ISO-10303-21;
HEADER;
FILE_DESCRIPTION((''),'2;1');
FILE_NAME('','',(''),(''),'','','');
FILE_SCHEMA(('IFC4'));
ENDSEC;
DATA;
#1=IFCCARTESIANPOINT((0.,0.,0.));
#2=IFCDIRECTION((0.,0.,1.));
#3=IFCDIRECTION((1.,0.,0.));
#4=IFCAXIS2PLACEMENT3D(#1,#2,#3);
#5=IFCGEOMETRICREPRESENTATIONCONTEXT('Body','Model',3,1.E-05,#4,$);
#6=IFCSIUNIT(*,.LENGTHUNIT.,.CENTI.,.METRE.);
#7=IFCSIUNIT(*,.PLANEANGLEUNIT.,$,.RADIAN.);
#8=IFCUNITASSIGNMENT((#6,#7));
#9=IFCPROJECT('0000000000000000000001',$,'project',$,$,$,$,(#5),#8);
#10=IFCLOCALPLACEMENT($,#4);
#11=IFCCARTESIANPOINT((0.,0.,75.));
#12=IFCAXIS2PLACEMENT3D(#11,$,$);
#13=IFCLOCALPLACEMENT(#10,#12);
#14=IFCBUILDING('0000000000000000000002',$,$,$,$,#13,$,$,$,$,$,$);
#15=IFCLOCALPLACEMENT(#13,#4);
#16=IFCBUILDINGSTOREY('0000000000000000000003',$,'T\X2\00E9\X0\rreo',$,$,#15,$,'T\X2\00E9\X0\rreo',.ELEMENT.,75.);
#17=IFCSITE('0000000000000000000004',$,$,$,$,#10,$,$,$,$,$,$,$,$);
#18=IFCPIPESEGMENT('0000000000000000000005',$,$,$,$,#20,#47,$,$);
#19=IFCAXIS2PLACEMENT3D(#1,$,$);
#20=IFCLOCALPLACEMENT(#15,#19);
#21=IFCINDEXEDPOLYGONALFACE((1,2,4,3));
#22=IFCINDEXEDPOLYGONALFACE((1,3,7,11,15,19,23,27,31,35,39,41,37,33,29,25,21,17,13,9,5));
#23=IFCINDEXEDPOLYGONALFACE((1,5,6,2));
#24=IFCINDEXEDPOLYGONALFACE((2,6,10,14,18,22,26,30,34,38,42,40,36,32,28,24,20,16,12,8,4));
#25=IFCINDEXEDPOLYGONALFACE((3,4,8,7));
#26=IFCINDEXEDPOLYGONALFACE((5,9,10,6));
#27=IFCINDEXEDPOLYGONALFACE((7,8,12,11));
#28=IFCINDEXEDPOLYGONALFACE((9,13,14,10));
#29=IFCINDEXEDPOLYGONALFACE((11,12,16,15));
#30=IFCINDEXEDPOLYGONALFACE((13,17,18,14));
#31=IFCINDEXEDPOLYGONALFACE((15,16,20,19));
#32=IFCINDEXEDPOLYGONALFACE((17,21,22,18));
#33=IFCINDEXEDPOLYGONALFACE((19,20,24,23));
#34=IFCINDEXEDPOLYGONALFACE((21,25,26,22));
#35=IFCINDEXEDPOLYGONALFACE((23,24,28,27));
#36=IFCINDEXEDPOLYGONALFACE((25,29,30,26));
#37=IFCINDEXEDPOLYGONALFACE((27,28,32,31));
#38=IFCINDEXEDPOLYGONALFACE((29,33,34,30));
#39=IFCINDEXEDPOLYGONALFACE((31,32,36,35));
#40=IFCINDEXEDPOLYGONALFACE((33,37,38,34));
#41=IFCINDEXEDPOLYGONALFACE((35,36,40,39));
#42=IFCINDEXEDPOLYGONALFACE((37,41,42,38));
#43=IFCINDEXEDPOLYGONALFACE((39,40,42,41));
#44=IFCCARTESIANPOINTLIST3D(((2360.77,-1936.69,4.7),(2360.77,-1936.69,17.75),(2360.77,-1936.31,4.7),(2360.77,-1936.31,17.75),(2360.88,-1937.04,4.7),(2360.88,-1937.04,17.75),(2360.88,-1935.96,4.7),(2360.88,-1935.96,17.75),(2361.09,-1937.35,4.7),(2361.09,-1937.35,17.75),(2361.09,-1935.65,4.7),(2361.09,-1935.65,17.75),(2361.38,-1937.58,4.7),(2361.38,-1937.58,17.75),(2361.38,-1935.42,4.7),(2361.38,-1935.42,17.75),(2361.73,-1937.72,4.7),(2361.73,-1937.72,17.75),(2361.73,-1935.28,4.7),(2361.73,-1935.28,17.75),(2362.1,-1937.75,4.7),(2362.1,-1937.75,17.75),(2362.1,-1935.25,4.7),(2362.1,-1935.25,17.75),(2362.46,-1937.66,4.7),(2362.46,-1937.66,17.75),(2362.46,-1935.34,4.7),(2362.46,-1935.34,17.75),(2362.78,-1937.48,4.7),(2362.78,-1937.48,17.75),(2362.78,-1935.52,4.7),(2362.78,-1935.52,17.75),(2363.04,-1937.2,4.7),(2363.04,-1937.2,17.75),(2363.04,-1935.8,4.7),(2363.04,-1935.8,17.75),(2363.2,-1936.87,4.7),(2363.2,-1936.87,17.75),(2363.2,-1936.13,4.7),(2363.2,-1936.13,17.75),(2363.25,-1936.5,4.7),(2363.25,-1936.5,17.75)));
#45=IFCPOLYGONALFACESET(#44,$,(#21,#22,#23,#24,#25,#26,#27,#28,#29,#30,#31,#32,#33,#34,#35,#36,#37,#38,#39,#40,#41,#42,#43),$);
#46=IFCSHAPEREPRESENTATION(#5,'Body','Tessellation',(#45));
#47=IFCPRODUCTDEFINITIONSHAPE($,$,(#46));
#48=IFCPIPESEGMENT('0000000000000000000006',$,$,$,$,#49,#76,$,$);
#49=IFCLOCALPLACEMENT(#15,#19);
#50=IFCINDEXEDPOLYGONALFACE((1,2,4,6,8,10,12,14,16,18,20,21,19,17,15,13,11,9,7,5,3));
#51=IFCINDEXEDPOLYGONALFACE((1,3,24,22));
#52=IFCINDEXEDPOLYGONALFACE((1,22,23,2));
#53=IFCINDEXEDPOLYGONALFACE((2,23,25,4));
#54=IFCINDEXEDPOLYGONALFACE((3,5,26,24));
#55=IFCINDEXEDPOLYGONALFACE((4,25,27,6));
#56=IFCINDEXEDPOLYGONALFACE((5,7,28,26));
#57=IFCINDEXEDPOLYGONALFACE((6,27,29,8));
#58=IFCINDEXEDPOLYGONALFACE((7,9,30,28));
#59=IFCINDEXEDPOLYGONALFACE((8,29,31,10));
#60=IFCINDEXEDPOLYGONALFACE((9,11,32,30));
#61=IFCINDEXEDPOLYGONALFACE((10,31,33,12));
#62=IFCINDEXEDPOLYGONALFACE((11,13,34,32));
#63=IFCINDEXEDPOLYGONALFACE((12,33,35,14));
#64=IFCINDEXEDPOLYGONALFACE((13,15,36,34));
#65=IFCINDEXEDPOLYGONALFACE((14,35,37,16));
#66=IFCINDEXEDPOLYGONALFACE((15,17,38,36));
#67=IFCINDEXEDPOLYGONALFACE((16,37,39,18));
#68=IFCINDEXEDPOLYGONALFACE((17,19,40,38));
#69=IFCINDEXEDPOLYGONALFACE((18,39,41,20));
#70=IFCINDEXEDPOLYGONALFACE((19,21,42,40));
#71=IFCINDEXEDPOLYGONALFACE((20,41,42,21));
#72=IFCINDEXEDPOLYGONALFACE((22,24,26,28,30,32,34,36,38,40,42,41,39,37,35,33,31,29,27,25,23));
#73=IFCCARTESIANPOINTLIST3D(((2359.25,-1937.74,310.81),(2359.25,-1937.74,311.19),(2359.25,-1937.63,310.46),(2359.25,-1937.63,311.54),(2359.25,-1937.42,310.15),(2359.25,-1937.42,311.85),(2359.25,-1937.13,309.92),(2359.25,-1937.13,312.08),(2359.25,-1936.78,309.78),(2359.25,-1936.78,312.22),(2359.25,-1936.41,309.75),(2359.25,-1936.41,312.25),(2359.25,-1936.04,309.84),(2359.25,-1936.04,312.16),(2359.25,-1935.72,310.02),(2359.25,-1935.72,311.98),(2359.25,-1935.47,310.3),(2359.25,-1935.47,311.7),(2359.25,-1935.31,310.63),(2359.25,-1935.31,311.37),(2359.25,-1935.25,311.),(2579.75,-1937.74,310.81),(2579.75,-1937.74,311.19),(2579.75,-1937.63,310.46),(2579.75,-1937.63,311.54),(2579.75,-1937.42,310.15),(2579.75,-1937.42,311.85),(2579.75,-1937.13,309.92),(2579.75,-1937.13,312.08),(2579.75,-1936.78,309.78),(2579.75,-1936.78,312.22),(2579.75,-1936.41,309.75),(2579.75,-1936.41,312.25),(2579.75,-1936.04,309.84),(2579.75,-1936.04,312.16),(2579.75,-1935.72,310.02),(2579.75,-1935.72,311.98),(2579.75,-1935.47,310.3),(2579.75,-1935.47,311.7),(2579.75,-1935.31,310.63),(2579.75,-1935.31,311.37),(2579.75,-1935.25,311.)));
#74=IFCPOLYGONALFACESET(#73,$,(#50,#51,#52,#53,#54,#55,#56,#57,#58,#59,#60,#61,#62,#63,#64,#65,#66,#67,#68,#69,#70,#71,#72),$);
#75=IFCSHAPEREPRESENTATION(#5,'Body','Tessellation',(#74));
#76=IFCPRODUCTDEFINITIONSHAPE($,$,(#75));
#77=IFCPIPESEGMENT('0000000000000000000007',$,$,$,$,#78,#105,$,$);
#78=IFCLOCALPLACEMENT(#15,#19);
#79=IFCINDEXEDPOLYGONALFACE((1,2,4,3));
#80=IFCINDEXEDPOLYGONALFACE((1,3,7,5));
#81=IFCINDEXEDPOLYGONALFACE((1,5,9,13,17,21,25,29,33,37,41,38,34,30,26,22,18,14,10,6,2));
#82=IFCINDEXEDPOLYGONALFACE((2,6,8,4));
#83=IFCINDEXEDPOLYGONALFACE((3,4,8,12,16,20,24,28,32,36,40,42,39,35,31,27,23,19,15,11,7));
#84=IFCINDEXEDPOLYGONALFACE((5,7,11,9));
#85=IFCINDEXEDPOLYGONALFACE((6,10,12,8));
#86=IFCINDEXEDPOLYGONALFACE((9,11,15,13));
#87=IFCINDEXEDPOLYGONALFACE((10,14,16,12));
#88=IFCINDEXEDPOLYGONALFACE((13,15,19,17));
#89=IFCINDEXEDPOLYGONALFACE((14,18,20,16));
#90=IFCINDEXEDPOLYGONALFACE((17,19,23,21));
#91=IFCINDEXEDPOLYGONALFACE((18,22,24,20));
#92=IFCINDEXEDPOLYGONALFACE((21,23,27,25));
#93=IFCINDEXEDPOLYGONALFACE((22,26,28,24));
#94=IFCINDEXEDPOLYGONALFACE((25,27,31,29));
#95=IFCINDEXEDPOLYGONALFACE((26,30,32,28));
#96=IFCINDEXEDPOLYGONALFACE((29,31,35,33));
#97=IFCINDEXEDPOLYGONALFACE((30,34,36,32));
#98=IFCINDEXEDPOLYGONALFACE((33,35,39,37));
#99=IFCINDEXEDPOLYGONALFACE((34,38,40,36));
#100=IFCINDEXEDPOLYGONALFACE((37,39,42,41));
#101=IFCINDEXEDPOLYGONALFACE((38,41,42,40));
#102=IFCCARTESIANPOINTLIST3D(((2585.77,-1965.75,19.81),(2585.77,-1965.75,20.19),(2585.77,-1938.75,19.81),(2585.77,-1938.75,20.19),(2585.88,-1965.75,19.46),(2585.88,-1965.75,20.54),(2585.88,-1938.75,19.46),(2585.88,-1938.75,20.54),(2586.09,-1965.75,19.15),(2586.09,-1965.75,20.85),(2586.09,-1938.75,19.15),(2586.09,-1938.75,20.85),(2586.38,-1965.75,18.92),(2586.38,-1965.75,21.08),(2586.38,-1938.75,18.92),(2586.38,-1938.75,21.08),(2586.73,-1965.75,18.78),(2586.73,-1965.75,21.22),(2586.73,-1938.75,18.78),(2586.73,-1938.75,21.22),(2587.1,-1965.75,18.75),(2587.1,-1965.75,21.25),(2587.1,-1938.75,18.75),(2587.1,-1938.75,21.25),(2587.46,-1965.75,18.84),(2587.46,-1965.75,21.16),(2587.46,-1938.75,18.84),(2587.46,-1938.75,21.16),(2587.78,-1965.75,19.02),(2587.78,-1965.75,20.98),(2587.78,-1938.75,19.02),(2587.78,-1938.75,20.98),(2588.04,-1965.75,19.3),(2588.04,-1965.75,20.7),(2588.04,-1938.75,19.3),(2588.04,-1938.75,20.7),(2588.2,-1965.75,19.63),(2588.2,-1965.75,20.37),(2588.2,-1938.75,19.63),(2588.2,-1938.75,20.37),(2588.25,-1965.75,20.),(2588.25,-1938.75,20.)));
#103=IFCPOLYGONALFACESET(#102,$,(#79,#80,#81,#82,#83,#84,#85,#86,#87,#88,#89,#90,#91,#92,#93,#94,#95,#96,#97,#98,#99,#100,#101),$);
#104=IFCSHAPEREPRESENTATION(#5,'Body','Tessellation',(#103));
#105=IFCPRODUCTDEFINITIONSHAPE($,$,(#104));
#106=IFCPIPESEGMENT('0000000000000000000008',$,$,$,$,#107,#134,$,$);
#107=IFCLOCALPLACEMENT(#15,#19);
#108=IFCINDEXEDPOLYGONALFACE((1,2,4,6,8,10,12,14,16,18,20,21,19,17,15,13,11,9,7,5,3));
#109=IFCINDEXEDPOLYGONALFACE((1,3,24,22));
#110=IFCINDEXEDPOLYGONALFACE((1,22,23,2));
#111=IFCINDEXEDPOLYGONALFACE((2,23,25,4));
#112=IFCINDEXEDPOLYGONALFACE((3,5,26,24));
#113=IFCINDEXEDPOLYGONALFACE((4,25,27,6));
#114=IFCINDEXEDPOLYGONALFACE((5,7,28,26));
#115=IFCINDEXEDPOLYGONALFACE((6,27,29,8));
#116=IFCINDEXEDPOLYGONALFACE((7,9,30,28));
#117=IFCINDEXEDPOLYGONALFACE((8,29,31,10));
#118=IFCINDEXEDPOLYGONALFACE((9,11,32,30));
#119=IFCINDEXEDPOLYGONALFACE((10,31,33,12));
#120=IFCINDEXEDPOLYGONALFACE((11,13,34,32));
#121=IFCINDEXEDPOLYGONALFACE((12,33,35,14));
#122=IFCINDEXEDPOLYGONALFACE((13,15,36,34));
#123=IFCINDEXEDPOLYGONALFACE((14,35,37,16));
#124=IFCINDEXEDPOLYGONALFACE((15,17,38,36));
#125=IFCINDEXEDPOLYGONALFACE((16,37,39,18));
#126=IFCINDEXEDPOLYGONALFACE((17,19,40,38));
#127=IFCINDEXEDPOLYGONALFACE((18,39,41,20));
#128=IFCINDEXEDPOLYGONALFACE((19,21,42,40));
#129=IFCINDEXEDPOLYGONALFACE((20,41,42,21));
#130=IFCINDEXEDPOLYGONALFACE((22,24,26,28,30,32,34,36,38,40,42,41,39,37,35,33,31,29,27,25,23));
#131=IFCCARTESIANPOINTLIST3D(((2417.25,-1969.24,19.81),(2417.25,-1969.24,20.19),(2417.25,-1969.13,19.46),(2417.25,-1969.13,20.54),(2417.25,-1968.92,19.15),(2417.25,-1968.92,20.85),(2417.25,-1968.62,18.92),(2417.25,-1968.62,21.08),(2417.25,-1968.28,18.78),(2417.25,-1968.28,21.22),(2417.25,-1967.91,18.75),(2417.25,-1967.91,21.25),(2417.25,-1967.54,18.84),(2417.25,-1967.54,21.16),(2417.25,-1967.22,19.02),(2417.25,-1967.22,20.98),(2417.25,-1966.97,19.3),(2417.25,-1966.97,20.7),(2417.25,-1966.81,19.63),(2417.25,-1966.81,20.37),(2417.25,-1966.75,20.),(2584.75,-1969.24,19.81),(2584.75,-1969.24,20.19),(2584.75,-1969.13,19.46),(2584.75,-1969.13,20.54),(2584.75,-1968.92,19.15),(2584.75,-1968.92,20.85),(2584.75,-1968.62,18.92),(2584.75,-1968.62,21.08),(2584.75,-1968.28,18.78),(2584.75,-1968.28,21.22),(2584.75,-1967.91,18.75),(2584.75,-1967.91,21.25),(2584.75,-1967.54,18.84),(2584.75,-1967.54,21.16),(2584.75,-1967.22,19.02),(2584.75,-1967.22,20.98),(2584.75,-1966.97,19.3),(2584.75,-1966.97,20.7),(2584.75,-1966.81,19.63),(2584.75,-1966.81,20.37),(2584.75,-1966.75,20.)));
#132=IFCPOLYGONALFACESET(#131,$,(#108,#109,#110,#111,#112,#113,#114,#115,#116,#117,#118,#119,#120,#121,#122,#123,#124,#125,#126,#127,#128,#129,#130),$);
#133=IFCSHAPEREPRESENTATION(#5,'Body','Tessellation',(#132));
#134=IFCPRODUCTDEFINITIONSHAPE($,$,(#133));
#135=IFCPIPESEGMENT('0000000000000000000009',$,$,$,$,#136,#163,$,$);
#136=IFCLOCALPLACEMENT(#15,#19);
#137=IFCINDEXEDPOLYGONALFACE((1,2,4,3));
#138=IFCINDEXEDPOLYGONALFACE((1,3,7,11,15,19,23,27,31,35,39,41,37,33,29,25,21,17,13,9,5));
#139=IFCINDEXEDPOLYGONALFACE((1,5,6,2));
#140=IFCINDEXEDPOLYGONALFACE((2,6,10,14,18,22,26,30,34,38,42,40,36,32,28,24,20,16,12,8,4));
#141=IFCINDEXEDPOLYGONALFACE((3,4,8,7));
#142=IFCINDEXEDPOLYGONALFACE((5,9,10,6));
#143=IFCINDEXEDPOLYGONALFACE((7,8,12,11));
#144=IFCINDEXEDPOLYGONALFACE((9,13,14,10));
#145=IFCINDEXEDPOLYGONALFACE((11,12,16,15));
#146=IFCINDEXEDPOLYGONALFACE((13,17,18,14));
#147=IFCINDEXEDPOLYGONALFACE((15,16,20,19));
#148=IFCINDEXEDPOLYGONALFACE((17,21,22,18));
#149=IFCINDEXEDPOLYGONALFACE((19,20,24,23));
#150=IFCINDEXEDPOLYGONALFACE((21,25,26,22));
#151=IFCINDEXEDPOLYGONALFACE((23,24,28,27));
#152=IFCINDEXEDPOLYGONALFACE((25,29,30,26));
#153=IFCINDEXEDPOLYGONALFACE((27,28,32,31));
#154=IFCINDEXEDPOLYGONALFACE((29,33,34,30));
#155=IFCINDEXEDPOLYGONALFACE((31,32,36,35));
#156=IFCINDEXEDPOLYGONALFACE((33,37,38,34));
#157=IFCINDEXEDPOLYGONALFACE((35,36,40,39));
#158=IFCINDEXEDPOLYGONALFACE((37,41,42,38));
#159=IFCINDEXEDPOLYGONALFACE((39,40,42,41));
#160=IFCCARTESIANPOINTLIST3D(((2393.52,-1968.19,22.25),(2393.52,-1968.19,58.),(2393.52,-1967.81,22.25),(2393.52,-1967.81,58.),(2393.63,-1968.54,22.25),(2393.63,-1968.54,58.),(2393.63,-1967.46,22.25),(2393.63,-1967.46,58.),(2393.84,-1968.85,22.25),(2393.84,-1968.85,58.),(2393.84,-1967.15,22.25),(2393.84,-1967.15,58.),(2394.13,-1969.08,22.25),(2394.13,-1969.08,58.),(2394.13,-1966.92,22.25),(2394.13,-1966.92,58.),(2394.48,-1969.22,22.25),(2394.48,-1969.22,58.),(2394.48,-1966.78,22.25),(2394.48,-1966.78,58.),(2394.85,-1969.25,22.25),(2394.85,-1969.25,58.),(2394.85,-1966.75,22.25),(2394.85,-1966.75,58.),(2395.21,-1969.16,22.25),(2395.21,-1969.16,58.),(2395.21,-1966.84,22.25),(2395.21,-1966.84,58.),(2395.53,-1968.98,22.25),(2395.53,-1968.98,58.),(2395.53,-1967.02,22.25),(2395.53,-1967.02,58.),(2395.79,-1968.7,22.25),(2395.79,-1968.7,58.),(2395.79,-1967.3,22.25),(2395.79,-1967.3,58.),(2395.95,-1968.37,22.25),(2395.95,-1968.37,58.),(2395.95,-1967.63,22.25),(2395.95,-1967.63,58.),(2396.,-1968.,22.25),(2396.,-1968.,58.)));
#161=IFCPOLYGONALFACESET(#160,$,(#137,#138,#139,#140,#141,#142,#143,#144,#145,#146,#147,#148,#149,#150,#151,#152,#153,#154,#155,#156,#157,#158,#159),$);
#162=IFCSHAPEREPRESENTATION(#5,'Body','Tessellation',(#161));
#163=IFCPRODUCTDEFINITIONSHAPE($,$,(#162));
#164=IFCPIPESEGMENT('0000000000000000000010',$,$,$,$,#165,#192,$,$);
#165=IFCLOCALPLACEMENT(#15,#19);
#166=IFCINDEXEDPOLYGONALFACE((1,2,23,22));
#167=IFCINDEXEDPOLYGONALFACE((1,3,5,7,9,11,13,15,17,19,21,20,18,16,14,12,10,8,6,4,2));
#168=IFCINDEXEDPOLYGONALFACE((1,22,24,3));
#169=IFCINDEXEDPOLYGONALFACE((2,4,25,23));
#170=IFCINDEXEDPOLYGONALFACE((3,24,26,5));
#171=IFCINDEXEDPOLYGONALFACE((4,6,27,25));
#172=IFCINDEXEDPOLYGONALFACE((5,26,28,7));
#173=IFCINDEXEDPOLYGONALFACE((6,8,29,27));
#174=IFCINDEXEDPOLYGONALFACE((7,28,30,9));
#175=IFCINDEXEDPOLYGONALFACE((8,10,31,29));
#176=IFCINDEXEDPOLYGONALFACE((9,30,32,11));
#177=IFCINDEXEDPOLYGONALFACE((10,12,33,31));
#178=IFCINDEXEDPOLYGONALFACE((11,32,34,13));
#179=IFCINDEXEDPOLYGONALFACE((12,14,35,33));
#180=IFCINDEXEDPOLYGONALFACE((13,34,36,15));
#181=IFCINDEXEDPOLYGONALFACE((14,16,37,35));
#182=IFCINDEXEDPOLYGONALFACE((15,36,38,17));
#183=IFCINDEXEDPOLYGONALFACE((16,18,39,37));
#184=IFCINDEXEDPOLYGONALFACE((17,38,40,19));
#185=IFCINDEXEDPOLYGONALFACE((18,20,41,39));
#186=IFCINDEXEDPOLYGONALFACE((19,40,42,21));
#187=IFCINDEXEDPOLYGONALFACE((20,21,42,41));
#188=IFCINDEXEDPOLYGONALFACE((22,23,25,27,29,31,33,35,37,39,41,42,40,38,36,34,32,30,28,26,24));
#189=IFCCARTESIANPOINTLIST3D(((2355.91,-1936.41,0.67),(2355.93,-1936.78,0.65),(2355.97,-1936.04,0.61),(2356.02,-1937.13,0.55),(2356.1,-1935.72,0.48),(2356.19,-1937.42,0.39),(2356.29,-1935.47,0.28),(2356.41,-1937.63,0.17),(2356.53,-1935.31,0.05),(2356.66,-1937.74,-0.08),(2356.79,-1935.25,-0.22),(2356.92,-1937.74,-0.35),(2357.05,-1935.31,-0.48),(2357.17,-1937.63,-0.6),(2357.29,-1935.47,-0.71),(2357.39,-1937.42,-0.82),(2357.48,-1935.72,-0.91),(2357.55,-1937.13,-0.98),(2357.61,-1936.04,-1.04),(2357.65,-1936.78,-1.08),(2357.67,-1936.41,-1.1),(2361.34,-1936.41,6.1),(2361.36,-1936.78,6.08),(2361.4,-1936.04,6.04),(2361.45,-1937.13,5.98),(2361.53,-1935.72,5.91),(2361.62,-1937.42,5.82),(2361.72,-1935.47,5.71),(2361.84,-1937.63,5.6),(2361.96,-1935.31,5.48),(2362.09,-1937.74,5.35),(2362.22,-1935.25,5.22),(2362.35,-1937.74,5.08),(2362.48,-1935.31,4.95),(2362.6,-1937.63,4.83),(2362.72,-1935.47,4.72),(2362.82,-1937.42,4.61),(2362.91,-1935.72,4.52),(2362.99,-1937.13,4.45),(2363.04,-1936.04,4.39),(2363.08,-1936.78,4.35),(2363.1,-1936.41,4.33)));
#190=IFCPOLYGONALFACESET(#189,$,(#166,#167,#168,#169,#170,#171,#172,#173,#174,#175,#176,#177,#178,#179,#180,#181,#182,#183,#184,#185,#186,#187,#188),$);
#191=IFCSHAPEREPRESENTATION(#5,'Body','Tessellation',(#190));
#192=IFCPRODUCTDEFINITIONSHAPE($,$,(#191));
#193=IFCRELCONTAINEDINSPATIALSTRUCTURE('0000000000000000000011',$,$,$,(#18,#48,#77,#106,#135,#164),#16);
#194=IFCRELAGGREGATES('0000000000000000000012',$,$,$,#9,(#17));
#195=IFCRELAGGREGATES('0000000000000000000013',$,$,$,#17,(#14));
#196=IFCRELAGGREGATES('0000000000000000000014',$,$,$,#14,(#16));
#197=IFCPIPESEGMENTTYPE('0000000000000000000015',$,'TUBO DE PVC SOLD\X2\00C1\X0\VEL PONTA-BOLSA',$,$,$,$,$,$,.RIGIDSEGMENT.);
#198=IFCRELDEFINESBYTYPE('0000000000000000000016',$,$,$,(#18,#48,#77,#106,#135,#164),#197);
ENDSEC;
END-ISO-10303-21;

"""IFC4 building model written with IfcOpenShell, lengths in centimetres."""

from ifc_helpers import new_model, si_unit, frame, origin_with_axes, origin_2d_with_axis, place, context, project, spatial, circle, extrude, type_object, element, save


model = new_model("IFC4")

# Units and contexts
model_context = context("Model", 3, precision=1e-05, world=origin_with_axes(), identifier="Body")
ifc_project = project(units=[si_unit("LENGTHUNIT", "METRE", prefix="CENTI"), si_unit("PLANEANGLEUNIT", "RADIAN")], contexts=[model_context])

# Site, building, storey
site_placement = place(None, origin_with_axes())
site = spatial("IfcSite", under=ifc_project, at=site_placement)
building_placement = place(site_placement, frame((0.0, 0.0, 75.0)))
building = spatial("IfcBuilding", under=site, at=building_placement)
storey_placement = place(building_placement, origin_with_axes())
storey = spatial("IfcBuildingStorey", under=building, at=storey_placement, Name="Térreo", LongName="Térreo", CompositionType="ELEMENT", Elevation=75.0)

# Pipe segments
pipe_segment_type_1 = type_object("IfcPipeSegmentType", Name="TUBO DE PVC SOLDÁVEL PONTA-BOLSA", PredefinedType="RIGIDSEGMENT")
pipe_segment_1_placement = place(storey_placement, frame((2362.0, -1936.5, 17.75), z_axis=(0.0, 0.0, 1.0), x_axis=(1.0, 0.0, 0.0)))
element("IfcPipeSegment", 1, at=pipe_segment_1_placement, inside=storey, type_object=pipe_segment_type_1, context=model_context, shape_type="SolidModel", body=[
    extrude(circle(Radius=1.25, at=origin_2d_with_axis()), frame((0.0, 0.0, 0.0), z_axis=(0.0, 0.0, -1.0), x_axis=(1.0, 0.0, 0.0)), (0.0, 0.0, 1.0), 13.05),
])
pipe_segment_2_placement = place(storey_placement, frame((2469.5, -1936.5, 312.25), z_axis=(0.0, 0.0, 1.0), x_axis=(1.0, 0.0, 0.0)))
element("IfcPipeSegment", 2, at=pipe_segment_2_placement, inside=storey, type_object=pipe_segment_type_1, context=model_context, shape_type="SolidModel", body=[
    extrude(circle(Radius=1.25, at=origin_2d_with_axis()), frame((-110.25, 0.0, -1.25), z_axis=(1.0, 0.0, 0.0), x_axis=(0.0, 1.0, 0.0)), (0.0, 0.0, 1.0), 220.5),
])
pipe_segment_3_placement = place(storey_placement, frame((2587.0, -1952.25, 21.25), z_axis=(0.0, 0.0, 1.0), x_axis=(1.0, 0.0, 0.0)))
element("IfcPipeSegment", 3, at=pipe_segment_3_placement, inside=storey, type_object=pipe_segment_type_1, context=model_context, shape_type="SolidModel", body=[
    extrude(circle(Radius=1.25, at=origin_2d_with_axis()), frame((0.0, 13.5, -1.25), z_axis=(0.0, -1.0, 0.0), x_axis=(1.0, 0.0, 0.0)), (0.0, 0.0, 1.0), 27.0),
])
pipe_segment_4_placement = place(storey_placement, frame((2501.0, -1968.0, 21.25), z_axis=(0.0, 0.0, 1.0), x_axis=(1.0, 0.0, 0.0)))
element("IfcPipeSegment", 4, at=pipe_segment_4_placement, inside=storey, type_object=pipe_segment_type_1, context=model_context, shape_type="SolidModel", body=[
    extrude(circle(Radius=1.25, at=origin_2d_with_axis()), frame((83.75, 0.0, -1.25), z_axis=(-1.0, 0.0, 0.0), x_axis=(0.0, 1.0, 0.0)), (0.0, 0.0, 1.0), 167.5),
])
pipe_segment_5_placement = place(storey_placement, frame((2394.75, -1968.0, 58.0), z_axis=(0.0, 0.0, 1.0), x_axis=(1.0, 0.0, 0.0)))
element("IfcPipeSegment", 5, at=pipe_segment_5_placement, inside=storey, type_object=pipe_segment_type_1, context=model_context, shape_type="SolidModel", body=[
    extrude(circle(Radius=1.25, at=origin_2d_with_axis()), frame((0.0, 0.0, -35.75), z_axis=(0.0, 0.0, 1.0), x_axis=(1.0, 0.0, 0.0)), (0.0, 0.0, 1.0), 35.75),
])
pipe_segment_6_placement = place(storey_placement, frame((2359.5, -1936.5, 6.1), z_axis=(0.0, 0.0, 1.0), x_axis=(1.0, 0.0, 0.0)))
element("IfcPipeSegment", 6, at=pipe_segment_6_placement, inside=storey, type_object=pipe_segment_type_1, context=model_context, shape_type="SolidModel", body=[
    extrude(circle(Radius=1.25, at=origin_2d_with_axis()), frame((2.72, 0.0, -0.88), z_axis=(-0.707107, 0.0, -0.707107), x_axis=(0.0, 1.0, 0.0)), (0.0, 0.0, 1.0), 7.68),
])

save(model, "model.ifc")
